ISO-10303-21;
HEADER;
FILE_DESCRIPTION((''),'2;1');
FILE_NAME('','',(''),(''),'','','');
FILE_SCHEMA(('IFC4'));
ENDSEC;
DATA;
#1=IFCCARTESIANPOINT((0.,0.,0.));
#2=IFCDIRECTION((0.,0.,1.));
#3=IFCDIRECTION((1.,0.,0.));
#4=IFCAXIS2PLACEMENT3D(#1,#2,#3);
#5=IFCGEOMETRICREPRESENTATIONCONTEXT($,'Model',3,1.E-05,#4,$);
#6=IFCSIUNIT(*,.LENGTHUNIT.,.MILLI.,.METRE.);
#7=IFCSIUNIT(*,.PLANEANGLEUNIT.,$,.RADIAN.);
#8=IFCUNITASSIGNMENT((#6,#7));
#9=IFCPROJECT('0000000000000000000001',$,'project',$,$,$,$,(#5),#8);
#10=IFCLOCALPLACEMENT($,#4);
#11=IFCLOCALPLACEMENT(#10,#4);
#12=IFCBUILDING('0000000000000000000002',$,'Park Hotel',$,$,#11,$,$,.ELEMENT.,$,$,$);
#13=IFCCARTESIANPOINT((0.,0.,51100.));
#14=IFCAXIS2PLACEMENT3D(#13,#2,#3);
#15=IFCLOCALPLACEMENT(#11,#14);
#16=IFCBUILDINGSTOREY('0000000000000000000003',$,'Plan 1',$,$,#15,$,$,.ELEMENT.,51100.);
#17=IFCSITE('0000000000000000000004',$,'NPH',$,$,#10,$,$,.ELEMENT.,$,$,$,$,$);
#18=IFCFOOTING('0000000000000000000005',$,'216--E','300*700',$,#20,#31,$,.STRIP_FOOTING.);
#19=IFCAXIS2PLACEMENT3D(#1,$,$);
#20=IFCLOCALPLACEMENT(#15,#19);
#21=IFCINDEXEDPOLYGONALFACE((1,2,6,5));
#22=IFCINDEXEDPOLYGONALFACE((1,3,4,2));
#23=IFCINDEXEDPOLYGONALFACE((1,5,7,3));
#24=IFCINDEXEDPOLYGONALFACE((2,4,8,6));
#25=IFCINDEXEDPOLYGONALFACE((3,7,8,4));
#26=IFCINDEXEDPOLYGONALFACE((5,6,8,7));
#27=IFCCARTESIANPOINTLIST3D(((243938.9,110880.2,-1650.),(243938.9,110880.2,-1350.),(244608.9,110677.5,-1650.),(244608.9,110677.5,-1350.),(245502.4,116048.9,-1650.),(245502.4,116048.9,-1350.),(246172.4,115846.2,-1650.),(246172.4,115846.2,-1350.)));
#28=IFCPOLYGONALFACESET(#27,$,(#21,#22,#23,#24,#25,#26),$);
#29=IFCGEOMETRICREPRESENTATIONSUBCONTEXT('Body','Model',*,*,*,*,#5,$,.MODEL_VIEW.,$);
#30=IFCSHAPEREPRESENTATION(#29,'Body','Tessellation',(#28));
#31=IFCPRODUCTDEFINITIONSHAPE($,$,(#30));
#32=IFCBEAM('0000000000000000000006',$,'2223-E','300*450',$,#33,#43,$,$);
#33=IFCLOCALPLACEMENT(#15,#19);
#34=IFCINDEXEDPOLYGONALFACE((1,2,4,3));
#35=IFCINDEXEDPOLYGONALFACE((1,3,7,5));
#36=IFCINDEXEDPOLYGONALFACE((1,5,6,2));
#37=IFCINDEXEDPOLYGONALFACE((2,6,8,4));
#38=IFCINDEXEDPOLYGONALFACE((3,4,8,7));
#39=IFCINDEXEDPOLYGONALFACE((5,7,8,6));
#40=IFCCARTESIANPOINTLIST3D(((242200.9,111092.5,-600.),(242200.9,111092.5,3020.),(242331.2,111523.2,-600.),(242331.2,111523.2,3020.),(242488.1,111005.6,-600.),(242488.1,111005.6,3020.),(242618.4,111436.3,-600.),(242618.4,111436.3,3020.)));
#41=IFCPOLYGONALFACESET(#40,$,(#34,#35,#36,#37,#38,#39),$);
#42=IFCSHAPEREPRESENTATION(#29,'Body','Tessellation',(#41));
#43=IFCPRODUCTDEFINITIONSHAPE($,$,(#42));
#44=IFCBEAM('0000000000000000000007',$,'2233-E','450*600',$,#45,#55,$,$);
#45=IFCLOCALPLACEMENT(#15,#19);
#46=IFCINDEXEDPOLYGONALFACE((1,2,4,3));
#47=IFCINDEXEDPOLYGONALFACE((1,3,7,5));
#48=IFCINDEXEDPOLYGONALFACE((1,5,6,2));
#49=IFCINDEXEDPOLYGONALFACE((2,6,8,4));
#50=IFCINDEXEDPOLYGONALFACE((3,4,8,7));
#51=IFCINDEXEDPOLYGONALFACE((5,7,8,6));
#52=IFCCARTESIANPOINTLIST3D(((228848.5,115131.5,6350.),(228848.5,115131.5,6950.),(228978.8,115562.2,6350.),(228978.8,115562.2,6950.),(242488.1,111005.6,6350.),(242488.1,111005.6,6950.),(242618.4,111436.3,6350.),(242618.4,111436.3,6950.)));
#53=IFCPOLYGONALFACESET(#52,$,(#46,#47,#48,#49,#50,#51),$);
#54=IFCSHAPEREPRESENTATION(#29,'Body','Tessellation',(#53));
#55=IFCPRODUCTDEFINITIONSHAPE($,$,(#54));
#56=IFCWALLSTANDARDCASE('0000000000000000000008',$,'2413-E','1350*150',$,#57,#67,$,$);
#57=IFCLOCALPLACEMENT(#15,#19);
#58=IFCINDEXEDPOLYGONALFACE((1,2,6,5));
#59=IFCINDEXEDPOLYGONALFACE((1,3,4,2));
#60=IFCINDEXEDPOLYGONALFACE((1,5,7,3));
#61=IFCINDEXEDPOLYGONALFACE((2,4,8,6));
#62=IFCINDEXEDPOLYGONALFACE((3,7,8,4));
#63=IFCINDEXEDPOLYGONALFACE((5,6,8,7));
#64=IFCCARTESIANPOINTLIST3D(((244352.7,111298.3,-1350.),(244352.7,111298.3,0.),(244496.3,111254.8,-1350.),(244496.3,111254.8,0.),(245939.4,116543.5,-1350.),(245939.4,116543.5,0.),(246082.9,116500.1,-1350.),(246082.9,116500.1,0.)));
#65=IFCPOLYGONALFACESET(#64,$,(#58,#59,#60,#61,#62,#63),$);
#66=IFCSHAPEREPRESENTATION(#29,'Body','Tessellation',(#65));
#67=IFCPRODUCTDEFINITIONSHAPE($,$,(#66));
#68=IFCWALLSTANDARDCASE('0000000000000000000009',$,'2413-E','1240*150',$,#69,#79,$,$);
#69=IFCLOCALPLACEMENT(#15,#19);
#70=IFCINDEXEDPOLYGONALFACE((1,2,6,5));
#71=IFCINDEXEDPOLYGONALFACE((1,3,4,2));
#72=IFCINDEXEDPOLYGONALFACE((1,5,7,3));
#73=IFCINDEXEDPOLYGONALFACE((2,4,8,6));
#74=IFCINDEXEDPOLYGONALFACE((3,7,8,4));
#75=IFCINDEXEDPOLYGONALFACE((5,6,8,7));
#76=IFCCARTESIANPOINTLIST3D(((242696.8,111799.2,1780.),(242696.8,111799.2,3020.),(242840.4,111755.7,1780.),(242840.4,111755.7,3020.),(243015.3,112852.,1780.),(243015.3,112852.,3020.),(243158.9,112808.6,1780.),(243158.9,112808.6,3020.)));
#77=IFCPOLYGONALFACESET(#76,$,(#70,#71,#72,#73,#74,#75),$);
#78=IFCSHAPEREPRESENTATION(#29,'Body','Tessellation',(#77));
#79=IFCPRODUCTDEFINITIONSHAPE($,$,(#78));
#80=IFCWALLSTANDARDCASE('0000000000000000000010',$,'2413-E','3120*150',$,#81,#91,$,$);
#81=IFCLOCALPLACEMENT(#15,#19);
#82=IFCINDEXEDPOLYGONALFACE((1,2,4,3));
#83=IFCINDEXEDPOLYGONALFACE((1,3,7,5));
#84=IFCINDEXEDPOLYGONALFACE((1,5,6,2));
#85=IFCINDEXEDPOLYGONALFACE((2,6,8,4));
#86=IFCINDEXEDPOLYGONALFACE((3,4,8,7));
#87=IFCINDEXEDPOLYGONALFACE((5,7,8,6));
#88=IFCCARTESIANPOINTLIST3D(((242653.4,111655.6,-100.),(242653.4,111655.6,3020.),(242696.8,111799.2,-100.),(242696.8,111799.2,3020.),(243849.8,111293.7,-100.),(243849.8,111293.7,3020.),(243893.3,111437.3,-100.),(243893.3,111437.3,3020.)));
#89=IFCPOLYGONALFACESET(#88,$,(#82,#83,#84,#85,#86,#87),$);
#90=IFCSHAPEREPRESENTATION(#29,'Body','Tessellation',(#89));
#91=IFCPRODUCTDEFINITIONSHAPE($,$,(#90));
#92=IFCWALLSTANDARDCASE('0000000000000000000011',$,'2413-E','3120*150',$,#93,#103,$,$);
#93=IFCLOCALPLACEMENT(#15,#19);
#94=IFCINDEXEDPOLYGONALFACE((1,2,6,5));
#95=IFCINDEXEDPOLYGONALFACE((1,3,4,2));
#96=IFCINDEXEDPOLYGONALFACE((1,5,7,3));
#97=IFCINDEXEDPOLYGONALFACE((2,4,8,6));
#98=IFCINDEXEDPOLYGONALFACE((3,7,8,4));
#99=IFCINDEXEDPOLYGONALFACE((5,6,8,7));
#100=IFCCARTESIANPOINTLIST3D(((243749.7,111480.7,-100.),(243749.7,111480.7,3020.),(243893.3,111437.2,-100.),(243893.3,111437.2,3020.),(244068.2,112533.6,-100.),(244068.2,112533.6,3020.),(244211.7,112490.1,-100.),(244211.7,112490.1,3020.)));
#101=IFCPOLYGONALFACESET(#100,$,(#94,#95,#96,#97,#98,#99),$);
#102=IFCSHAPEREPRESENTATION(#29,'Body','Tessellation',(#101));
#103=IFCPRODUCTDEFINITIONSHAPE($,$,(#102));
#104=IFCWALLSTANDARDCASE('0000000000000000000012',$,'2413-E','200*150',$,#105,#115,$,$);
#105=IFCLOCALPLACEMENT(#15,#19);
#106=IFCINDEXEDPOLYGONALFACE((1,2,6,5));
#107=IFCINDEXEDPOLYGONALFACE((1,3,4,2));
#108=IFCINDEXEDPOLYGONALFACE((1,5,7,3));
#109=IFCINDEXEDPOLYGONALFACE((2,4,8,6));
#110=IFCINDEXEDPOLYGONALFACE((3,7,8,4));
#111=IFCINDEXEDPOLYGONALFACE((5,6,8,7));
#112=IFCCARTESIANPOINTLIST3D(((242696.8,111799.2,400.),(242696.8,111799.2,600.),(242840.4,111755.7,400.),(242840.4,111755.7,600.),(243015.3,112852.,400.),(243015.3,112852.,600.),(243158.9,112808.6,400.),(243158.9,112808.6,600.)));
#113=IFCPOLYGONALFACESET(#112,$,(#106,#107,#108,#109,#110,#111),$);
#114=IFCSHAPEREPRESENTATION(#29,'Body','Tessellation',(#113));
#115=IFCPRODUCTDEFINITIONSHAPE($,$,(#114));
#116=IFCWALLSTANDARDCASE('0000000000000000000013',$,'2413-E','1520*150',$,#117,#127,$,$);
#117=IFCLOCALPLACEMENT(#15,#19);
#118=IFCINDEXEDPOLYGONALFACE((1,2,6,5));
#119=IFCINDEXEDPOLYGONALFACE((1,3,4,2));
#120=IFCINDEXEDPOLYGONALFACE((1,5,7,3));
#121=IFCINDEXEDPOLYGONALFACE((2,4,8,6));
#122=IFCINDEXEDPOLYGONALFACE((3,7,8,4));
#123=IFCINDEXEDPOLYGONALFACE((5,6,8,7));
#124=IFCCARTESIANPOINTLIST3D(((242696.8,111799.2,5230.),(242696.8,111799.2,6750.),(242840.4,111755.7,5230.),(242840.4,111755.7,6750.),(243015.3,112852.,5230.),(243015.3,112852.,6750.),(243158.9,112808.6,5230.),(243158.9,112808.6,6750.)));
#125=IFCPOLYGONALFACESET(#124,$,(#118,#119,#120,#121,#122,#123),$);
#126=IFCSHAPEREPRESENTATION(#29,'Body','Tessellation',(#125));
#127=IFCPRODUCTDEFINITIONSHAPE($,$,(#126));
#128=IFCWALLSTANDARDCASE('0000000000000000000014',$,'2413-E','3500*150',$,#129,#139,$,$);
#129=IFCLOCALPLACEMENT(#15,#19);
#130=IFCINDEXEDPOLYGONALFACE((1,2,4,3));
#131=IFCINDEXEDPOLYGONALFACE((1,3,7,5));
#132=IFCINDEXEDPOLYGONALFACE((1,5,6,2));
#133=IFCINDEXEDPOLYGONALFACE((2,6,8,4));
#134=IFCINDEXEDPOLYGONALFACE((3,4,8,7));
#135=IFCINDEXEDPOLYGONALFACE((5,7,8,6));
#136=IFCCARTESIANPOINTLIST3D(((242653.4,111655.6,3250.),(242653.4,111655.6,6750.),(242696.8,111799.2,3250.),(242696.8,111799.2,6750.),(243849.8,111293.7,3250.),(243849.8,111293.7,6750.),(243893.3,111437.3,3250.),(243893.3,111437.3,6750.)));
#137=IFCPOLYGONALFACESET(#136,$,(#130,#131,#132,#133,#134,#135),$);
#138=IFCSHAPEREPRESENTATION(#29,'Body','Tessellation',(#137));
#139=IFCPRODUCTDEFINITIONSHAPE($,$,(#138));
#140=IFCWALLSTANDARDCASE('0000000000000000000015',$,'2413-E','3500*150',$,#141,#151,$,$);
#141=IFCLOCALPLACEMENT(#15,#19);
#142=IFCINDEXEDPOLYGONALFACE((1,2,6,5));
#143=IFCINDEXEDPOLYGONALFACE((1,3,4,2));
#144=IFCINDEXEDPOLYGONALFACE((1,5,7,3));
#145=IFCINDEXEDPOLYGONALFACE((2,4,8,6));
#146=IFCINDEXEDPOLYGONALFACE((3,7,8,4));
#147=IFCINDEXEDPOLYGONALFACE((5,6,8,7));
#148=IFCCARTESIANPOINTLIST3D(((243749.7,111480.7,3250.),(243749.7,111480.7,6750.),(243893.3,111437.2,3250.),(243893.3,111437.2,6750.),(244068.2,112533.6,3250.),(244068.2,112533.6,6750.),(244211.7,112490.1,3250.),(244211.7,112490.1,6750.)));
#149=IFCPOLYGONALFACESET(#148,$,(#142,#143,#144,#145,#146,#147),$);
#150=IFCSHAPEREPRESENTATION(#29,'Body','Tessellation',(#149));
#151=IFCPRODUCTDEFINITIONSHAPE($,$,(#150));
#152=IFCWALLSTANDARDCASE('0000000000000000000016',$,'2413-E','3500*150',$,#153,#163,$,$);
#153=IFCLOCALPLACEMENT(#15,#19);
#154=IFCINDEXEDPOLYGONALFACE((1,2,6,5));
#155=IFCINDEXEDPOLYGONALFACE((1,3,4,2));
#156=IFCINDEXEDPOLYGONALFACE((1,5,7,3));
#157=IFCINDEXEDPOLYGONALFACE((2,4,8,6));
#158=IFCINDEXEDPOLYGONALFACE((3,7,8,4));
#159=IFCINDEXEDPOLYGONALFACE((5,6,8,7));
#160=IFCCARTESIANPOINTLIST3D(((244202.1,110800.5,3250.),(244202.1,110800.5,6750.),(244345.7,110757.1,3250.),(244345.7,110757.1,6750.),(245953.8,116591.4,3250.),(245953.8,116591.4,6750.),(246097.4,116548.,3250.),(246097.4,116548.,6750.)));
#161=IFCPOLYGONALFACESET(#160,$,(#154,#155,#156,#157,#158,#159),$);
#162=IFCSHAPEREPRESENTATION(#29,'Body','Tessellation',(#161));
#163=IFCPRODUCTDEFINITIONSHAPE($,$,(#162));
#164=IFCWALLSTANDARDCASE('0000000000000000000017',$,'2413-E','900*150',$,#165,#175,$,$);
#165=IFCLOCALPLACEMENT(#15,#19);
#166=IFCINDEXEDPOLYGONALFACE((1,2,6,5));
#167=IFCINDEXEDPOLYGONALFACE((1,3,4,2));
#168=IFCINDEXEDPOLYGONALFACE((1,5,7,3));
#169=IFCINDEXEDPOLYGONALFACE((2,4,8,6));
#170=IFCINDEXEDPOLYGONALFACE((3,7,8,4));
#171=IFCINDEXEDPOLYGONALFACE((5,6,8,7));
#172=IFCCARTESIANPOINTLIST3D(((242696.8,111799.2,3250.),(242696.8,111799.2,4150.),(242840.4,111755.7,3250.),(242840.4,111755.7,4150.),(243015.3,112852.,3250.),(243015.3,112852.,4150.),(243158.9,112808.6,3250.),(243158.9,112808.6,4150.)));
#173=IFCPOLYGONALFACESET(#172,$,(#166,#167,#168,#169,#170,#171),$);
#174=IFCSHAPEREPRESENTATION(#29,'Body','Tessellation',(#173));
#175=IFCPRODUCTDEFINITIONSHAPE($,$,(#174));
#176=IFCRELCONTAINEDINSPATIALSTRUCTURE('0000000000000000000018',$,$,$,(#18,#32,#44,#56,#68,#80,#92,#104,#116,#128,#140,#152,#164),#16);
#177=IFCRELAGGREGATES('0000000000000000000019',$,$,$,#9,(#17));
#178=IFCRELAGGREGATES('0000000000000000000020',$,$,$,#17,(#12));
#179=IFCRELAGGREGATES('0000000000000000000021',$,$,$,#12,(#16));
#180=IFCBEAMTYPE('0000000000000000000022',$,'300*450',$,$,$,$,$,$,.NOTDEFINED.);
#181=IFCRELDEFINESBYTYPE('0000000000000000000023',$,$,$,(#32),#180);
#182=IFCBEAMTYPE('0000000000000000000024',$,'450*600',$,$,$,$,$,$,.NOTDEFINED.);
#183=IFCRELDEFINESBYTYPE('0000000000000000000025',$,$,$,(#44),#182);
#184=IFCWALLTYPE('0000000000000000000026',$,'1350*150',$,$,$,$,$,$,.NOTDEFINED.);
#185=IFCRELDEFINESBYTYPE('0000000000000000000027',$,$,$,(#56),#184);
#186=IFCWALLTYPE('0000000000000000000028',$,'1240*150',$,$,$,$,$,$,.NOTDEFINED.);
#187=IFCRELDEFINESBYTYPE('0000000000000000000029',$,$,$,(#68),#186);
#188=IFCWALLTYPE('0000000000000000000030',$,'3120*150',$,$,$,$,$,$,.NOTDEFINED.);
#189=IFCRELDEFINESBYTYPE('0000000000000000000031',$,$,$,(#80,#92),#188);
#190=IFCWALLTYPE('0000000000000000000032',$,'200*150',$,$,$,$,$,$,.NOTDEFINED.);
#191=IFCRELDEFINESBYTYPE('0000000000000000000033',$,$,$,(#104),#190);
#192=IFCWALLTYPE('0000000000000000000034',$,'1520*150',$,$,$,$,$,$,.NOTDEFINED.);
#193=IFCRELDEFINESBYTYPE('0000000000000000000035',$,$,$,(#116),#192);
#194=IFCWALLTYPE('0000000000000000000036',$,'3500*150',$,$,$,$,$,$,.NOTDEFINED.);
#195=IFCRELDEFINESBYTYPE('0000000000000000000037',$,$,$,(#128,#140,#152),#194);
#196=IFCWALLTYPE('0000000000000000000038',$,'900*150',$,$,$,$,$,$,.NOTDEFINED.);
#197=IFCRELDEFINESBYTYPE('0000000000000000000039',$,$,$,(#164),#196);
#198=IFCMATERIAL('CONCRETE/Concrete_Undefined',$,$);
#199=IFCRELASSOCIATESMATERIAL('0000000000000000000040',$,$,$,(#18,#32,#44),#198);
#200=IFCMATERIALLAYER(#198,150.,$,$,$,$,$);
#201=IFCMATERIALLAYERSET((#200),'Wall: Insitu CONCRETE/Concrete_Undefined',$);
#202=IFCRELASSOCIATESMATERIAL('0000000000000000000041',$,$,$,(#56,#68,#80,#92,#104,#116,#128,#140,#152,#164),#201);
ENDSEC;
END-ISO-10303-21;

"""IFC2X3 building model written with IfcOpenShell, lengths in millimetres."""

from ifc_helpers import new_model, si_unit, frame, frame_2d, origin_with_axes, origin_2d_with_axis, place, context, subcontext, project, spatial, rectangle, extrude, material, layer, layer_set, layer_usage, type_object, element, save


model = new_model("IFC2X3")

# Units and contexts
model_context = context("Model", 3, precision=1e-05, world=origin_with_axes())
body_context = subcontext(model_context, "Body", "Model", "MODEL_VIEW")
ifc_project = project(units=[si_unit("LENGTHUNIT", "METRE", prefix="MILLI"), si_unit("PLANEANGLEUNIT", "RADIAN")], contexts=[model_context])

# Site, building, storey
site_placement = place(None, origin_with_axes())
site = spatial("IfcSite", under=ifc_project, at=site_placement, Name="NPH", CompositionType="ELEMENT")
building_placement = place(site_placement, origin_with_axes())
building = spatial("IfcBuilding", under=site, at=building_placement, Name="Park Hotel", CompositionType="ELEMENT")
storey_placement = place(building_placement, frame((0.0, 0.0, 51100.0), z_axis=(0.0, 0.0, 1.0), x_axis=(1.0, 0.0, 0.0)))
storey = spatial("IfcBuildingStorey", under=building, at=storey_placement, Name="Plan 1", CompositionType="ELEMENT", Elevation=51100.0)

# Footing
ifc_material_1 = material(Name="CONCRETE/Concrete_Undefined")
footing_placement = place(storey_placement, frame((244273.9, 110778.8, -1500.0), z_axis=(0.0, 0.0, 1.0), x_axis=(0.289538, 0.957167, 0.0)))
element("IfcFooting", 1, at=footing_placement, inside=storey, material=ifc_material_1, Name="216--E", Description="300*700", PredefinedType="STRIP_FOOTING", context=body_context, shape_type="SweptSolid", body=[
    extrude(rectangle(XDim=700.0, YDim=300.0, at=origin_2d_with_axis()), frame((5400.0, 0.0, 0.0), z_axis=(-1.0, 0.0, 0.0), x_axis=(0.0, -1.0, 0.0)), (0.0, 0.0, 1.0), 5400.0),
])

# Beams
beam_type_1 = type_object("IfcBeamType", Name="300*450", PredefinedType="NOTDEFINED")
beam_1_placement = place(storey_placement, frame((242409.7, 111264.4, -600.0), z_axis=(0.957167, -0.289538, 0.0), x_axis=(0.0, 0.0, 1.0)))
element("IfcBeam", 2, at=beam_1_placement, inside=storey, type_object=beam_type_1, material=ifc_material_1, Name="2223-E", Description="300*450", context=body_context, shape_type="SweptSolid", body=[
    extrude(rectangle(XDim=450.0, YDim=300.0, at=origin_2d_with_axis()), frame((3620.0, 0.0, 0.0), z_axis=(-1.0, 0.0, 0.0), x_axis=(0.0, -1.0, 0.0)), (0.0, 0.0, 1.0), 3620.0),
])
beam_type_2 = type_object("IfcBeamType", Name="450*600", PredefinedType="NOTDEFINED")
beam_2_placement = place(storey_placement, frame((242553.2, 111221.0, 6650.0), z_axis=(-0.289538, -0.957167, 0.0), x_axis=(-0.957167, 0.289538, 0.0)))
element("IfcBeam", 3, at=beam_2_placement, inside=storey, type_object=beam_type_2, material=ifc_material_1, Name="2233-E", Description="450*600", context=body_context, shape_type="SweptSolid", body=[
    extrude(rectangle(XDim=600.0, YDim=450.0, at=origin_2d_with_axis()), frame((14250.0, 0.0, 0.0), z_axis=(-1.0, 0.0, 0.0), x_axis=(0.0, -1.0, 0.0)), (0.0, 0.0, 1.0), 14250.0),
])

# Walls
ifc_layer_1 = layer(ifc_material_1, 150.0)
ifc_layer_set_1 = layer_set([ifc_layer_1], Name="Wall: Insitu CONCRETE/Concrete_Undefined")
ifc_layer_usage_1 = layer_usage(ifc_layer_set_1, "AXIS2", "POSITIVE", -75.0)
wall_type_1 = type_object("IfcWallType", Name="1350*150", PredefinedType="NOTDEFINED")
wall_1_placement = place(storey_placement, frame((244424.5, 111276.5, -1350.0), z_axis=(0.0, 0.0, 1.0), x_axis=(0.289537, 0.957167, 0.0)))
element("IfcWallStandardCase", 4, at=wall_1_placement, inside=storey, type_object=wall_type_1, material=ifc_layer_usage_1, Name="2413-E", Description="1350*150", context=body_context, shape_type="SweptSolid", body=[
    extrude(rectangle(XDim=5480.0, YDim=150.0, at=frame_2d((0.0, 2740.0), x_axis=(0.0, -1.0))), frame((0.0, 0.0, 0.0), z_axis=(0.0, 0.0, 1.0), x_axis=(0.0, -1.0, 0.0)), (0.0, 0.0, 1.0), 1350.0),
])
ifc_layer_usage_2 = layer_usage(ifc_layer_set_1, "AXIS2", "POSITIVE", -75.0)
wall_type_2 = type_object("IfcWallType", Name="1240*150", PredefinedType="NOTDEFINED")
wall_2_placement = place(storey_placement, frame((242768.6, 111777.4, 1780.0), z_axis=(0.0, 0.0, 1.0), x_axis=(0.289534, 0.957168, 0.0)))
element("IfcWallStandardCase", 5, at=wall_2_placement, inside=storey, type_object=wall_type_2, material=ifc_layer_usage_2, Name="2413-E", Description="1240*150", context=body_context, shape_type="SweptSolid", body=[
    extrude(rectangle(XDim=1100.0, YDim=150.0, at=frame_2d((0.0, 550.0), x_axis=(0.0, -1.0))), frame((0.0, 0.0, 0.0), z_axis=(0.0, 0.0, 1.0), x_axis=(0.0, -1.0, 0.0)), (0.0, 0.0, 1.0), 1240.0),
])
ifc_layer_usage_3 = layer_usage(ifc_layer_set_1, "AXIS2", "POSITIVE", -75.0)
wall_type_3 = type_object("IfcWallType", Name="3120*150", PredefinedType="NOTDEFINED")
wall_3_placement = place(storey_placement, frame((242675.1, 111727.4, -100.0), z_axis=(0.0, 0.0, 1.0), x_axis=(0.957168, -0.289532, 0.0)))
element("IfcWallStandardCase", 6, at=wall_3_placement, inside=storey, type_object=wall_type_3, material=ifc_layer_usage_3, Name="2413-E", Description="3120*150", context=body_context, shape_type="SweptSolid", body=[
    extrude(rectangle(XDim=1250.0, YDim=150.0, at=frame_2d((0.0, 625.0), x_axis=(0.0, -1.0))), frame((0.0, 0.0, 0.0), z_axis=(0.0, 0.0, 1.0), x_axis=(0.0, -1.0, 0.0)), (0.0, 0.0, 1.0), 3120.0),
])
ifc_layer_usage_4 = layer_usage(ifc_layer_set_1, "AXIS2", "POSITIVE", -75.0)
wall_4_placement = place(storey_placement, frame((244140.0, 112511.8, -100.0), z_axis=(0.0, 0.0, 1.0), x_axis=(-0.289534, -0.957168, 0.0)))
element("IfcWallStandardCase", 7, at=wall_4_placement, inside=storey, type_object=wall_type_3, material=ifc_layer_usage_4, Name="2413-E", Description="3120*150", context=body_context, shape_type="SweptSolid", body=[
    extrude(rectangle(XDim=1100.0, YDim=150.0, at=frame_2d((0.0, 550.0), x_axis=(0.0, -1.0))), frame((0.0, 0.0, 0.0), z_axis=(0.0, 0.0, 1.0), x_axis=(0.0, -1.0, 0.0)), (0.0, 0.0, 1.0), 3120.0),
])
ifc_layer_usage_5 = layer_usage(ifc_layer_set_1, "AXIS2", "POSITIVE", -75.0)
wall_type_4 = type_object("IfcWallType", Name="200*150", PredefinedType="NOTDEFINED")
wall_5_placement = place(storey_placement, frame((242768.6, 111777.4, 400.0), z_axis=(0.0, 0.0, 1.0), x_axis=(0.289534, 0.957168, 0.0)))
element("IfcWallStandardCase", 8, at=wall_5_placement, inside=storey, type_object=wall_type_4, material=ifc_layer_usage_5, Name="2413-E", Description="200*150", context=body_context, shape_type="SweptSolid", body=[
    extrude(rectangle(XDim=1100.0, YDim=150.0, at=frame_2d((0.0, 550.0), x_axis=(0.0, -1.0))), frame((0.0, 0.0, 0.0), z_axis=(0.0, 0.0, 1.0), x_axis=(0.0, -1.0, 0.0)), (0.0, 0.0, 1.0), 200.0),
])
ifc_layer_usage_6 = layer_usage(ifc_layer_set_1, "AXIS2", "POSITIVE", -75.0)
wall_type_5 = type_object("IfcWallType", Name="1520*150", PredefinedType="NOTDEFINED")
wall_6_placement = place(storey_placement, frame((242768.6, 111777.4, 5230.0), z_axis=(0.0, 0.0, 1.0), x_axis=(0.289534, 0.957168, 0.0)))
element("IfcWallStandardCase", 9, at=wall_6_placement, inside=storey, type_object=wall_type_5, material=ifc_layer_usage_6, Name="2413-E", Description="1520*150", context=body_context, shape_type="SweptSolid", body=[
    extrude(rectangle(XDim=1100.0, YDim=150.0, at=frame_2d((0.0, 550.0), x_axis=(0.0, -1.0))), frame((0.0, 0.0, 0.0), z_axis=(0.0, 0.0, 1.0), x_axis=(0.0, -1.0, 0.0)), (0.0, 0.0, 1.0), 1520.0),
])
ifc_layer_usage_7 = layer_usage(ifc_layer_set_1, "AXIS2", "POSITIVE", -75.0)
wall_type_6 = type_object("IfcWallType", Name="3500*150", PredefinedType="NOTDEFINED")
wall_7_placement = place(storey_placement, frame((242675.1, 111727.4, 3250.0), z_axis=(0.0, 0.0, 1.0), x_axis=(0.957168, -0.289532, 0.0)))
element("IfcWallStandardCase", 10, at=wall_7_placement, inside=storey, type_object=wall_type_6, material=ifc_layer_usage_7, Name="2413-E", Description="3500*150", context=body_context, shape_type="SweptSolid", body=[
    extrude(rectangle(XDim=1250.0, YDim=150.0, at=frame_2d((0.0, 625.0), x_axis=(0.0, -1.0))), frame((0.0, 0.0, 0.0), z_axis=(0.0, 0.0, 1.0), x_axis=(0.0, -1.0, 0.0)), (0.0, 0.0, 1.0), 3500.0),
])
ifc_layer_usage_8 = layer_usage(ifc_layer_set_1, "AXIS2", "POSITIVE", -75.0)
wall_8_placement = place(storey_placement, frame((244140.0, 112511.8, 3250.0), z_axis=(0.0, 0.0, 1.0), x_axis=(-0.289534, -0.957168, 0.0)))
element("IfcWallStandardCase", 11, at=wall_8_placement, inside=storey, type_object=wall_type_6, material=ifc_layer_usage_8, Name="2413-E", Description="3500*150", context=body_context, shape_type="SweptSolid", body=[
    extrude(rectangle(XDim=1100.0, YDim=150.0, at=frame_2d((0.0, 550.0), x_axis=(0.0, -1.0))), frame((0.0, 0.0, 0.0), z_axis=(0.0, 0.0, 1.0), x_axis=(0.0, -1.0, 0.0)), (0.0, 0.0, 1.0), 3500.0),
])
ifc_layer_usage_9 = layer_usage(ifc_layer_set_1, "AXIS2", "POSITIVE", -75.0)
wall_9_placement = place(storey_placement, frame((244273.9, 110778.8, 3250.0), z_axis=(0.0, 0.0, 1.0), x_axis=(0.289537, 0.957167, 0.0)))
element("IfcWallStandardCase", 12, at=wall_9_placement, inside=storey, type_object=wall_type_6, material=ifc_layer_usage_9, Name="2413-E", Description="3500*150", context=body_context, shape_type="SweptSolid", body=[
    extrude(rectangle(XDim=6050.0, YDim=150.0, at=frame_2d((0.0, 3025.0), x_axis=(0.0, -1.0))), frame((0.0, 0.0, 0.0), z_axis=(0.0, 0.0, 1.0), x_axis=(0.0, -1.0, 0.0)), (0.0, 0.0, 1.0), 3500.0),
])
ifc_layer_usage_10 = layer_usage(ifc_layer_set_1, "AXIS2", "POSITIVE", -75.0)
wall_type_7 = type_object("IfcWallType", Name="900*150", PredefinedType="NOTDEFINED")
wall_10_placement = place(storey_placement, frame((242768.6, 111777.4, 3250.0), z_axis=(0.0, 0.0, 1.0), x_axis=(0.289534, 0.957168, 0.0)))
element("IfcWallStandardCase", 13, at=wall_10_placement, inside=storey, type_object=wall_type_7, material=ifc_layer_usage_10, Name="2413-E", Description="900*150", context=body_context, shape_type="SweptSolid", body=[
    extrude(rectangle(XDim=1100.0, YDim=150.0, at=frame_2d((0.0, 550.0), x_axis=(0.0, -1.0))), frame((0.0, 0.0, 0.0), z_axis=(0.0, 0.0, 1.0), x_axis=(0.0, -1.0, 0.0)), (0.0, 0.0, 1.0), 900.0),
])

save(model, "model.ifc")
